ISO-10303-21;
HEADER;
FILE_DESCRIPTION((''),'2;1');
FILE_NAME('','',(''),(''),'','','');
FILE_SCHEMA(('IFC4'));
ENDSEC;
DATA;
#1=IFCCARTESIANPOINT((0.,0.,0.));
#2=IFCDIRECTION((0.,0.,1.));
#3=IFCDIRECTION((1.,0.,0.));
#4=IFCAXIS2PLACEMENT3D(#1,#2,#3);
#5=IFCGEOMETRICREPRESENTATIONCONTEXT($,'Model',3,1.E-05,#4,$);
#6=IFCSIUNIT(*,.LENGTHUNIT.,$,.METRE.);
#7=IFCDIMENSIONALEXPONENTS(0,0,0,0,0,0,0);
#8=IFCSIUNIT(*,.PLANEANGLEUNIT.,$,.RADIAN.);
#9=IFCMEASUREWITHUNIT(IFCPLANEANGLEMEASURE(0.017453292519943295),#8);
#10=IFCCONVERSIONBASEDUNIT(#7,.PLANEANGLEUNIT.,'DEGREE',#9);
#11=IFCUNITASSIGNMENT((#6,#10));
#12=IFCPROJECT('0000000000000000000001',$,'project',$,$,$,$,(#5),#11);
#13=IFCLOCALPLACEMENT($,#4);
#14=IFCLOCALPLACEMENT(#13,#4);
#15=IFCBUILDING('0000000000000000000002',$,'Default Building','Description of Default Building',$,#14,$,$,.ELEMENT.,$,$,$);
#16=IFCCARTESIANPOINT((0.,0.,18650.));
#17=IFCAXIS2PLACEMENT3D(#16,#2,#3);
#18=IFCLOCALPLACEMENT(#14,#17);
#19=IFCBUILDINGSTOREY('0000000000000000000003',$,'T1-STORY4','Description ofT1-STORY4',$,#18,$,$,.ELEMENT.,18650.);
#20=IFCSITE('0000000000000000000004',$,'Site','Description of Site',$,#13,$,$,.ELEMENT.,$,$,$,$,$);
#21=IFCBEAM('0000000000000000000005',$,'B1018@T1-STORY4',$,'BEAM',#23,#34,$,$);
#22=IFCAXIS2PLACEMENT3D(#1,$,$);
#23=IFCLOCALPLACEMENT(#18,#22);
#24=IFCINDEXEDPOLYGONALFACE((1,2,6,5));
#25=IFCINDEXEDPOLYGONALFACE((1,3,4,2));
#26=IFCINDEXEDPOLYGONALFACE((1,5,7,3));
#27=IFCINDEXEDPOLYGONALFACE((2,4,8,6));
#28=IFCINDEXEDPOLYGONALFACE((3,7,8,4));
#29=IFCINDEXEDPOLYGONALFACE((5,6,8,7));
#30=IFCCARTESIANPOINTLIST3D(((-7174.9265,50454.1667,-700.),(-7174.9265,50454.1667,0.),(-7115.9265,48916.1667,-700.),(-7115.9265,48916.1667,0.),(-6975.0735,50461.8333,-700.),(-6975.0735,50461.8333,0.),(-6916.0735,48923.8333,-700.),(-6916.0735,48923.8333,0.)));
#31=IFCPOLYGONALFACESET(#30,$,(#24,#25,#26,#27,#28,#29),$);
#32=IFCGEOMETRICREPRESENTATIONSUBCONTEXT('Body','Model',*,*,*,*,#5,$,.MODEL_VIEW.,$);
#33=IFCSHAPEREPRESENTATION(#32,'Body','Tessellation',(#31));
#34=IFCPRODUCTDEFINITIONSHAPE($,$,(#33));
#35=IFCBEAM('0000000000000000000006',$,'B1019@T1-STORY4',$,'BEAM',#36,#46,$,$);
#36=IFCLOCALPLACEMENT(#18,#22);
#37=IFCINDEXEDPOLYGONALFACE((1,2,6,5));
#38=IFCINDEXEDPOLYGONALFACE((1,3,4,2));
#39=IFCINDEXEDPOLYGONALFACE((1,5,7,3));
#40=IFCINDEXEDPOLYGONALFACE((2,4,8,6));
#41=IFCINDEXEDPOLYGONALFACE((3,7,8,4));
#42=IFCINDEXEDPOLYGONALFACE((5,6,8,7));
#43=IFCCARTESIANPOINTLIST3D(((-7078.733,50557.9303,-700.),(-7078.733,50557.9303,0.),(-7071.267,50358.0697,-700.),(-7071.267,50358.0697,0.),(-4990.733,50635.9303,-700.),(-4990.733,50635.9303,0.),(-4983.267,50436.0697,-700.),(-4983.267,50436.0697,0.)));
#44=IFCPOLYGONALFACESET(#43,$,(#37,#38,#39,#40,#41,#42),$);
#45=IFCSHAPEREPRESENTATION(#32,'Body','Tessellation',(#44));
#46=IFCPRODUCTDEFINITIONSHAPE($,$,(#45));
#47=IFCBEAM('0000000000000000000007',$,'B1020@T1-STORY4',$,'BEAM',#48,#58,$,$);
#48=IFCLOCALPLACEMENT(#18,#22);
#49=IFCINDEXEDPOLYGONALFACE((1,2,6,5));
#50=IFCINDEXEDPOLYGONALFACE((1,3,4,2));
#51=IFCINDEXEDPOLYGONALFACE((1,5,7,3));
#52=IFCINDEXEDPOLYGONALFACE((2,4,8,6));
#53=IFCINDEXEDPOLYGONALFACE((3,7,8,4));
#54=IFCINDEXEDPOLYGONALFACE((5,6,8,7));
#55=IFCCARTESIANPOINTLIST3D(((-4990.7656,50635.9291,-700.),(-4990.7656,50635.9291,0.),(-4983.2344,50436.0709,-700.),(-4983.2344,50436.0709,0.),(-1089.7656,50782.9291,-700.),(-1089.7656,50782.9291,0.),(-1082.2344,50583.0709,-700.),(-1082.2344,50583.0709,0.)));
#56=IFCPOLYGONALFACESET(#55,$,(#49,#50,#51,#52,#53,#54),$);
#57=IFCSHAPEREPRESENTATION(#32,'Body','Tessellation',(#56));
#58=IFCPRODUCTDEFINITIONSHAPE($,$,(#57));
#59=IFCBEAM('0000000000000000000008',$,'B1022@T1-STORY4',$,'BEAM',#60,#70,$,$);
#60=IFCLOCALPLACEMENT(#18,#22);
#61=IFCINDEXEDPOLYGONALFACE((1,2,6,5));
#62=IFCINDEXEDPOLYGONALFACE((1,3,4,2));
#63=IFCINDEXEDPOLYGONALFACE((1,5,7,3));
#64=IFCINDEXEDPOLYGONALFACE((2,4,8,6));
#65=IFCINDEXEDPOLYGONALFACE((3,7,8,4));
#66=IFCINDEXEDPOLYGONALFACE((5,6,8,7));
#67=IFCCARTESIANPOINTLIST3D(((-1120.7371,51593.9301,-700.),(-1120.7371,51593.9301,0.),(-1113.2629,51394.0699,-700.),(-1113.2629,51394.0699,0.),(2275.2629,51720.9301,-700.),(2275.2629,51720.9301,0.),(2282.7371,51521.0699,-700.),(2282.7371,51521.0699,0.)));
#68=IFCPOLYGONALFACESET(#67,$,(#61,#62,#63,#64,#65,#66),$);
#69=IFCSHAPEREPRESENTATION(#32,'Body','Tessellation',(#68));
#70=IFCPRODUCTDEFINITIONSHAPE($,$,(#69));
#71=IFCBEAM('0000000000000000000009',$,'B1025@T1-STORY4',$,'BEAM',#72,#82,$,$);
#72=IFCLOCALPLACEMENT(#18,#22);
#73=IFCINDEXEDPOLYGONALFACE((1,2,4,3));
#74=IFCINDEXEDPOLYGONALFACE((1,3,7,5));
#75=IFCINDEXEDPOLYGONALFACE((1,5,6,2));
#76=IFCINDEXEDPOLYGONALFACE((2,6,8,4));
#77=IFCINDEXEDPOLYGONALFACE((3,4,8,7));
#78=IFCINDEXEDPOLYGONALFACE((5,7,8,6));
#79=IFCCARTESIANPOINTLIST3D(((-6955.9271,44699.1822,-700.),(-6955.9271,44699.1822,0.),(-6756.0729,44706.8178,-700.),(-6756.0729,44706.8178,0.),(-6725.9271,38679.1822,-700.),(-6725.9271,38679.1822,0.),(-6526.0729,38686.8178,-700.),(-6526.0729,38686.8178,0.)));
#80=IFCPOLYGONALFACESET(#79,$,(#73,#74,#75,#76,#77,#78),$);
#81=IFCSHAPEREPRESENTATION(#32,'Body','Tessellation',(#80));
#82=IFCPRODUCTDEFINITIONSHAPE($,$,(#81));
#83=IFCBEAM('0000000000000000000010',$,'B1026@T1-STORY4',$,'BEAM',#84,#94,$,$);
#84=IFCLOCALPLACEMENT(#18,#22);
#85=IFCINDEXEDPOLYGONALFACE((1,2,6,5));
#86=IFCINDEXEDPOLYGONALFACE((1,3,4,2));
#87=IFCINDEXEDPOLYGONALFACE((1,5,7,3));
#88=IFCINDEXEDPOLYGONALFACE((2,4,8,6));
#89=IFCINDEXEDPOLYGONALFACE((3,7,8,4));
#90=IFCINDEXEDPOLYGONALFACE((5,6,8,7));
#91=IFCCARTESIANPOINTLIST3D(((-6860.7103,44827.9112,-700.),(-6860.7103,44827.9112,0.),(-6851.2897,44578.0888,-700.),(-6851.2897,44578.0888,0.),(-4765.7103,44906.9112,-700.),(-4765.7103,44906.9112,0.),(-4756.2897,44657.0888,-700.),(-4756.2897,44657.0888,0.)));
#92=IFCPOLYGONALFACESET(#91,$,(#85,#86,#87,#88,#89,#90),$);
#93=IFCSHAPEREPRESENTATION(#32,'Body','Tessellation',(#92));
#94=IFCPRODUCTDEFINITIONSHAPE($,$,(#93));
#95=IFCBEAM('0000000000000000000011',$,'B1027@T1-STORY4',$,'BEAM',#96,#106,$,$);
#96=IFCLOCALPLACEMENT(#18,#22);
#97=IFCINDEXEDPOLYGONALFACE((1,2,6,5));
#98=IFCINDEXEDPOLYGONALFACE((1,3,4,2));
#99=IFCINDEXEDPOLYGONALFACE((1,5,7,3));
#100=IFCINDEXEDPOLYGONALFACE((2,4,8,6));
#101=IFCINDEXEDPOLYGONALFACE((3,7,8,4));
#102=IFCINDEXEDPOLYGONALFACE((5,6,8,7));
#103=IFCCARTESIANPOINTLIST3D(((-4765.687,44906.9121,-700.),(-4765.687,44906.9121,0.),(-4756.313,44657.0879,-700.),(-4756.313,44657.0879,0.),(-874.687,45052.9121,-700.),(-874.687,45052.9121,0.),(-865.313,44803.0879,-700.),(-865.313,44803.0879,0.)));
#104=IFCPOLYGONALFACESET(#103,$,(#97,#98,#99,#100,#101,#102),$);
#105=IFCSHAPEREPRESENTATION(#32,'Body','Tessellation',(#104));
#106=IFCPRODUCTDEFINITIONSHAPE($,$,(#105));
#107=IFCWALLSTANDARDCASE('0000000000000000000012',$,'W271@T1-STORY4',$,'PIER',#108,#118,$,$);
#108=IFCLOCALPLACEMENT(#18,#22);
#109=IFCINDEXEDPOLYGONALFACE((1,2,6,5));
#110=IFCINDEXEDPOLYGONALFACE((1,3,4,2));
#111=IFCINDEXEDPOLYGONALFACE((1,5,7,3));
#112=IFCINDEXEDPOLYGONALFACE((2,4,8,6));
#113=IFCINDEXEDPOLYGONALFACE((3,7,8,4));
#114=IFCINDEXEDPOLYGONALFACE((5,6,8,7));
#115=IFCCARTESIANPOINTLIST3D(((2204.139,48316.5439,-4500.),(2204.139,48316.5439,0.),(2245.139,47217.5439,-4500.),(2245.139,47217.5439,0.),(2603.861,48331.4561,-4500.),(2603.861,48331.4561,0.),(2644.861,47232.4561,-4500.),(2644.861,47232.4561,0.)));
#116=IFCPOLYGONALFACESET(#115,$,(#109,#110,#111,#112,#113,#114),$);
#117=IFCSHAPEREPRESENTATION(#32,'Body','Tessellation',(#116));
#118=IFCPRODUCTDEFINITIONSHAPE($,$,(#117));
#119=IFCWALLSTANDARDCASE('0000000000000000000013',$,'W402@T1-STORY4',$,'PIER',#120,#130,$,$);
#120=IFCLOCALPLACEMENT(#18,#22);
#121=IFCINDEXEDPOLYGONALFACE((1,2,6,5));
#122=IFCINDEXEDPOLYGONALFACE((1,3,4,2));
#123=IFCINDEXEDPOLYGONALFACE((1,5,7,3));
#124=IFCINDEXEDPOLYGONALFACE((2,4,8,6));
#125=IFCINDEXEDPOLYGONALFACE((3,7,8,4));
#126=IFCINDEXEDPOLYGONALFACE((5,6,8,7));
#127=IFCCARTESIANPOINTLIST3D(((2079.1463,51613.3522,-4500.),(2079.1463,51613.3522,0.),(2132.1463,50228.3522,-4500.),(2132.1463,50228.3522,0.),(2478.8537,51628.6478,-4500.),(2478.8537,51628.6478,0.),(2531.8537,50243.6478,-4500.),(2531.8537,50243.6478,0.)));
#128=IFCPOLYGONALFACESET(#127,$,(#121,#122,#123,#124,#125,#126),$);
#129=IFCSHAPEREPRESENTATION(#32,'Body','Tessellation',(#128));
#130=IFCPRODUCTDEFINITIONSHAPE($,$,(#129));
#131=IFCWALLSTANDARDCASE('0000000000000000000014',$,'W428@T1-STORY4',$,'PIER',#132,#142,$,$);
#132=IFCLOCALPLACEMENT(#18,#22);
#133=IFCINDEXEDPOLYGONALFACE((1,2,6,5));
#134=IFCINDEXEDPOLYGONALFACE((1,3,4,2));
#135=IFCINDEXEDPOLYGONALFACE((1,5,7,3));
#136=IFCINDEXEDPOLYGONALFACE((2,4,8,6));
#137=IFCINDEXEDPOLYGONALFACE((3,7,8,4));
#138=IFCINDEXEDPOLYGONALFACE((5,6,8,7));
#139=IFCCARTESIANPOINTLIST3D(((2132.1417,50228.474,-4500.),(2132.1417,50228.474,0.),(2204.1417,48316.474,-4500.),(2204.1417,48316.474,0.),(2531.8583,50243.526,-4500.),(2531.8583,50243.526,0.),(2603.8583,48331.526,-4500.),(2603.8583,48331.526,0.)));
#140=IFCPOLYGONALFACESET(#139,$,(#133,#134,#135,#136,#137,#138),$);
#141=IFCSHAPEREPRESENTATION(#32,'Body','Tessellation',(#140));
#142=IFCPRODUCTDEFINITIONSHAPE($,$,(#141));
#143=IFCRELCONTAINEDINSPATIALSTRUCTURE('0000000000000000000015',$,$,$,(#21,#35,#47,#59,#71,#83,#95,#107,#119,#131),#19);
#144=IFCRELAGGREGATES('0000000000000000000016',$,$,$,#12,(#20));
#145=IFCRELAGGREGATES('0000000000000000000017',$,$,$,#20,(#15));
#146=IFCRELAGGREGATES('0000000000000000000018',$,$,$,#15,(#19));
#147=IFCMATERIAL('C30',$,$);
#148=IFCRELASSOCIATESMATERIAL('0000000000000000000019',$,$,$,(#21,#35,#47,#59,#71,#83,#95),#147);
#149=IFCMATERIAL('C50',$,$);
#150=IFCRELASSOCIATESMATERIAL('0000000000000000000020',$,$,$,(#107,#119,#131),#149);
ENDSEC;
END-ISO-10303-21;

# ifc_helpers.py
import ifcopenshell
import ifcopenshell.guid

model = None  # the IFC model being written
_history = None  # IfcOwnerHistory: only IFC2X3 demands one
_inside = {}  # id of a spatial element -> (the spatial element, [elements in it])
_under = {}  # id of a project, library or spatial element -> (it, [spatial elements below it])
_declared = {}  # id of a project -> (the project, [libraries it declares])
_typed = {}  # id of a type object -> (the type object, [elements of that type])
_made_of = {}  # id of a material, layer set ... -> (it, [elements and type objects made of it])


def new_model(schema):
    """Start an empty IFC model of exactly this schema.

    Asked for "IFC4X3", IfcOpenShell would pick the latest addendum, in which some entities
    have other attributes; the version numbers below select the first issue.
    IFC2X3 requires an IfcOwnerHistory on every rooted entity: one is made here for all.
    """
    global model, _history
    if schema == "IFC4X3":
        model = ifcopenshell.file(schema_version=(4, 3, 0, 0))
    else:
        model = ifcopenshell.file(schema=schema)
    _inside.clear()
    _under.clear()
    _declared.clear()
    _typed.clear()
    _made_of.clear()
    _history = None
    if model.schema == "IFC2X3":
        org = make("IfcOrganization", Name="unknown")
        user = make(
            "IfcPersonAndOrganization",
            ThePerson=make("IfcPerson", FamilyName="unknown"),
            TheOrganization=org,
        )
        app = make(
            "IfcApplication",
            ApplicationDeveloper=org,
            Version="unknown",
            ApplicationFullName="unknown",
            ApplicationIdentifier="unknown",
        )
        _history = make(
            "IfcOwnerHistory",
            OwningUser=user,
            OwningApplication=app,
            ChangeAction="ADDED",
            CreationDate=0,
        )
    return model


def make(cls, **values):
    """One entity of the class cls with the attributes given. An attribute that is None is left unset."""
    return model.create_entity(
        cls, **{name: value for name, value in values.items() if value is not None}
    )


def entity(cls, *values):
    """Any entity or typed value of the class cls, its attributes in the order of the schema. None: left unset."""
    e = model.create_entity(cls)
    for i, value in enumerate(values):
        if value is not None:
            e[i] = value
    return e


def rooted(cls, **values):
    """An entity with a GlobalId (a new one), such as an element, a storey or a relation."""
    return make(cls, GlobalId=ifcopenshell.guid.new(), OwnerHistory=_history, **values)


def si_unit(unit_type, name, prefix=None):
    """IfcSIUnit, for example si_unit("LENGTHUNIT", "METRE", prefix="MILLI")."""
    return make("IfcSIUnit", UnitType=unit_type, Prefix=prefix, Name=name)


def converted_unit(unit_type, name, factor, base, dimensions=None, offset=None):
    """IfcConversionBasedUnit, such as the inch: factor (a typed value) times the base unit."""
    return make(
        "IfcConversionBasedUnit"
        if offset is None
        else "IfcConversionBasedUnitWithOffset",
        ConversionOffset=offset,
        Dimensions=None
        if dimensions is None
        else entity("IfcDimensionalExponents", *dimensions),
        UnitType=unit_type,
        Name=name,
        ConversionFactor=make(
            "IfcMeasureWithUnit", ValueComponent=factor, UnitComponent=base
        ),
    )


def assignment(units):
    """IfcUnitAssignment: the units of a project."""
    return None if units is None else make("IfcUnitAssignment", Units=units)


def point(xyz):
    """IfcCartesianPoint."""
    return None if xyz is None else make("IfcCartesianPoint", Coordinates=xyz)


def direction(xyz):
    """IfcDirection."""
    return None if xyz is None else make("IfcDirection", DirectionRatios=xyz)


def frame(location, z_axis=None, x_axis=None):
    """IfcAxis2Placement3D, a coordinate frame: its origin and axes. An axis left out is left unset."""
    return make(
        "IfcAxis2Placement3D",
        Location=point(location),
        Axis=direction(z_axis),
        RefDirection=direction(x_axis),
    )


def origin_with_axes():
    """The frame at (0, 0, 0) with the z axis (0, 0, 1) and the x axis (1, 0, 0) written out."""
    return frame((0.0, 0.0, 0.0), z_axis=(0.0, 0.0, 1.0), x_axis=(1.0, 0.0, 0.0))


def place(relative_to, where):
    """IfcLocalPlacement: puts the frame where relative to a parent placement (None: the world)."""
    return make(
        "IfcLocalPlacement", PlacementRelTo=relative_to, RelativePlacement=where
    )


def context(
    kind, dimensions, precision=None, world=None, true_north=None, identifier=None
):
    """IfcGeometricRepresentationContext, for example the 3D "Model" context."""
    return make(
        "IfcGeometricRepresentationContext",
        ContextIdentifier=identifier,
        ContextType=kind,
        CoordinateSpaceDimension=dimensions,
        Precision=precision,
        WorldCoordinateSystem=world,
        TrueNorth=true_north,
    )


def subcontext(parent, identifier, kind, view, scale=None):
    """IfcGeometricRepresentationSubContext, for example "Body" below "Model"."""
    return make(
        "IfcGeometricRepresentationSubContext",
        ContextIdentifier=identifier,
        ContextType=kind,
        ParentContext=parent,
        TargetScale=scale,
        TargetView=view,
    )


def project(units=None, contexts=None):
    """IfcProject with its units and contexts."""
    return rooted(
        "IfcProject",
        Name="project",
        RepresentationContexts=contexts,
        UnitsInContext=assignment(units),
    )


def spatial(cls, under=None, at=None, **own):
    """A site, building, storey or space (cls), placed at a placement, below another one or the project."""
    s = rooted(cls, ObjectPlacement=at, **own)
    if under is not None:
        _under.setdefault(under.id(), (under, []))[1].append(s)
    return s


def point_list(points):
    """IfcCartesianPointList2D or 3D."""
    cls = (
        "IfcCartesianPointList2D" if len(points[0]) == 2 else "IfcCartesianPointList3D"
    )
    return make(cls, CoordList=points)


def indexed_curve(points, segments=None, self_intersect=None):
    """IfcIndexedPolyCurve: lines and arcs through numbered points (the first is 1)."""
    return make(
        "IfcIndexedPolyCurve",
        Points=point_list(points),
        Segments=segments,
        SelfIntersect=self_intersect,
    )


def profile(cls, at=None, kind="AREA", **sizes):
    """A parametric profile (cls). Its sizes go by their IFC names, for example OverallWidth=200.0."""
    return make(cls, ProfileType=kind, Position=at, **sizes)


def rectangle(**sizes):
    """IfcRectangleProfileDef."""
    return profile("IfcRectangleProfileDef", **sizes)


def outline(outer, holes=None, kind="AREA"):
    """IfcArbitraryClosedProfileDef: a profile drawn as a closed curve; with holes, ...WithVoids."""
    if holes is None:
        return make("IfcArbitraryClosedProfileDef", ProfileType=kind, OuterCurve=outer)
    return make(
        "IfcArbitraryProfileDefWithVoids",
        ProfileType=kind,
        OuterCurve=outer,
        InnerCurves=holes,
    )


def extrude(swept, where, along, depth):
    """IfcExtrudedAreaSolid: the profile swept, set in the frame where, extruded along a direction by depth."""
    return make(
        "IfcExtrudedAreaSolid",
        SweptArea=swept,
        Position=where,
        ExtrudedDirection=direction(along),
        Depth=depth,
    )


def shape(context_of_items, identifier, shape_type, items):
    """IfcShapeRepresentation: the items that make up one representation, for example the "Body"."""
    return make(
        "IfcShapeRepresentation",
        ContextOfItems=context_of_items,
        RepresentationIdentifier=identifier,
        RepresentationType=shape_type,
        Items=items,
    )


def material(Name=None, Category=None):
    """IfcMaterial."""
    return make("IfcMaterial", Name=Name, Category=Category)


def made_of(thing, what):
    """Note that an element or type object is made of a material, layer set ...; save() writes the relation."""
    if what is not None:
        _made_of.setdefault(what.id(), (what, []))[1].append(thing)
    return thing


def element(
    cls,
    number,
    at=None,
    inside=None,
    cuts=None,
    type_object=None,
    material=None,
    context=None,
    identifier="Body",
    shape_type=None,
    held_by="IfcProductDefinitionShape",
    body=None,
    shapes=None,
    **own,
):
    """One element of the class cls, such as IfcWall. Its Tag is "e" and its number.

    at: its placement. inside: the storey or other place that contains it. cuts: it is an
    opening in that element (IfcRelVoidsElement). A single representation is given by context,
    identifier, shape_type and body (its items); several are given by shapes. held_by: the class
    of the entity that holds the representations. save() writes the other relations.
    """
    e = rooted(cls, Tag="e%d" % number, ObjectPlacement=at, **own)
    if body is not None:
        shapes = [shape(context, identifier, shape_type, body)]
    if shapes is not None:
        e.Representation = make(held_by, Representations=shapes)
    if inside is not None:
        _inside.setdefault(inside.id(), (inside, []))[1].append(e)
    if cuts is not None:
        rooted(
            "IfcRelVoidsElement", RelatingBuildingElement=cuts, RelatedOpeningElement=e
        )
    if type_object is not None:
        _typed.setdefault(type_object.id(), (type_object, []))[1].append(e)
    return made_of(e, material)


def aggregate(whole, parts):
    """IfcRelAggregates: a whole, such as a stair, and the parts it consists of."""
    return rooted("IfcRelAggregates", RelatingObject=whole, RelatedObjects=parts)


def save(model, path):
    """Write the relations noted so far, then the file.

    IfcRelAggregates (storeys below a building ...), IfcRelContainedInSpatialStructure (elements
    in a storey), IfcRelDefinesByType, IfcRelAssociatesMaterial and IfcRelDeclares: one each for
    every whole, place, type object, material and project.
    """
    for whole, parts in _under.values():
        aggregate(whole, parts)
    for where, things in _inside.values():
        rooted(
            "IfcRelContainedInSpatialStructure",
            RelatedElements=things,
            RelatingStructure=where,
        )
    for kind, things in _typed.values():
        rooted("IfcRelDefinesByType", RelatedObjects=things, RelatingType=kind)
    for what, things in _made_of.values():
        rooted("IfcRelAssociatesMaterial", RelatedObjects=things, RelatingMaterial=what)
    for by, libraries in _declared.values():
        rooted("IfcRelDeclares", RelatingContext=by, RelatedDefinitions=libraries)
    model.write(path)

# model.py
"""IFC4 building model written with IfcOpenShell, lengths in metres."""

from ifc_helpers import new_model, entity, si_unit, converted_unit, frame, origin_with_axes, place, context, subcontext, project, spatial, indexed_curve, rectangle, outline, extrude, material, element, save


model = new_model("IFC4")

# Units and contexts
model_context = context("Model", 3, precision=1e-05, world=origin_with_axes())
body_context = subcontext(model_context, "Body", "Model", "MODEL_VIEW")
ifc_project = project(units=[si_unit("LENGTHUNIT", "METRE"), converted_unit("PLANEANGLEUNIT", "DEGREE", entity("IfcPlaneAngleMeasure", 0.017453292519943295), si_unit("PLANEANGLEUNIT", "RADIAN"), dimensions=[0, 0, 0, 0, 0, 0, 0])], contexts=[model_context])

# Site, building, storey
site_placement = place(None, origin_with_axes())
site = spatial("IfcSite", under=ifc_project, at=site_placement, Name="Site", Description="Description of Site", CompositionType="ELEMENT")
building_placement = place(site_placement, origin_with_axes())
building = spatial("IfcBuilding", under=site, at=building_placement, Name="Default Building", Description="Description of Default Building", CompositionType="ELEMENT")
storey_placement = place(building_placement, frame((0.0, 0.0, 18650.0), z_axis=(0.0, 0.0, 1.0), x_axis=(1.0, 0.0, 0.0)))
storey = spatial("IfcBuildingStorey", under=building, at=storey_placement, Name="T1-STORY4", Description="Description ofT1-STORY4", CompositionType="ELEMENT", Elevation=18650.0)

# Beams
ifc_material_1 = material(Name="C30")
beam_1_placement = place(storey_placement, frame((-7075.0, 50458.0, -350.0), z_axis=(0.038333, -0.999265, 0.0), x_axis=(0.999265, 0.038333, 0.0)))
element("IfcBeam", 1, at=beam_1_placement, inside=storey, material=ifc_material_1, Name="B1018@T1-STORY4", ObjectType="BEAM", context=body_context, shape_type="SweptSolid", body=[
    extrude(rectangle(XDim=200.0, YDim=700.0), origin_with_axes(), (0.0, 0.0, 1.0), 1539.1312),
])
beam_2_placement = place(storey_placement, frame((-7075.0, 50458.0, -350.0), z_axis=(0.999303, 0.03733, 0.0), x_axis=(-0.03733, 0.999303, 0.0)))
element("IfcBeam", 2, at=beam_2_placement, inside=storey, material=ifc_material_1, Name="B1019@T1-STORY4", ObjectType="BEAM", context=body_context, shape_type="SweptSolid", body=[
    extrude(rectangle(XDim=200.0, YDim=700.0), origin_with_axes(), (0.0, 0.0, 1.0), 2089.4564),
])
beam_3_placement = place(storey_placement, frame((-4987.0, 50536.0, -350.0), z_axis=(0.999291, 0.037656, 0.0), x_axis=(-0.037656, 0.999291, 0.0)))
element("IfcBeam", 3, at=beam_3_placement, inside=storey, material=ifc_material_1, Name="B1020@T1-STORY4", ObjectType="BEAM", context=body_context, shape_type="SweptSolid", body=[
    extrude(rectangle(XDim=200.0, YDim=700.0), origin_with_axes(), (0.0, 0.0, 1.0), 3903.7687),
])
beam_4_placement = place(storey_placement, frame((-1117.0, 51494.0, -350.0), z_axis=(0.999301, 0.037371, 0.0), x_axis=(-0.037371, 0.999301, 0.0)))
element("IfcBeam", 4, at=beam_4_placement, inside=storey, material=ifc_material_1, Name="B1022@T1-STORY4", ObjectType="BEAM", context=body_context, shape_type="SweptSolid", body=[
    extrude(rectangle(XDim=200.0, YDim=700.0), origin_with_axes(), (0.0, 0.0, 1.0), 3398.3739),
])
beam_5_placement = place(storey_placement, frame((-6856.0, 44703.0, -350.0), z_axis=(0.038178, -0.999271, 0.0), x_axis=(0.999271, 0.038178, 0.0)))
element("IfcBeam", 5, at=beam_5_placement, inside=storey, material=ifc_material_1, Name="B1025@T1-STORY4", ObjectType="BEAM", context=body_context, shape_type="SweptSolid", body=[
    extrude(rectangle(XDim=200.0, YDim=700.0), origin_with_axes(), (0.0, 0.0, 1.0), 6024.3921),
])
beam_6_placement = place(storey_placement, frame((-6856.0, 44703.0, -350.0), z_axis=(0.99929, 0.037682, 0.0), x_axis=(-0.037682, 0.99929, 0.0)))
element("IfcBeam", 6, at=beam_6_placement, inside=storey, material=ifc_material_1, Name="B1026@T1-STORY4", ObjectType="BEAM", context=body_context, shape_type="SweptSolid", body=[
    extrude(rectangle(XDim=250.0, YDim=700.0), origin_with_axes(), (0.0, 0.0, 1.0), 2096.489),
])
beam_7_placement = place(storey_placement, frame((-4761.0, 44782.0, -350.0), z_axis=(0.999297, 0.037496, 0.0), x_axis=(-0.037496, 0.999297, 0.0)))
element("IfcBeam", 7, at=beam_7_placement, inside=storey, material=ifc_material_1, Name="B1027@T1-STORY4", ObjectType="BEAM", context=body_context, shape_type="SweptSolid", body=[
    extrude(rectangle(XDim=250.0, YDim=700.0), origin_with_axes(), (0.0, 0.0, 1.0), 3893.7382),
])
ifc_material_2 = material(Name="C50")

# Walls
wall_1_placement = place(storey_placement, frame((2404.0, 48324.0, -4500.0), z_axis=(0.0, 0.0, 1.0), x_axis=(0.037281, -0.999305, 0.0)))
element("IfcWallStandardCase", 8, at=wall_1_placement, inside=storey, material=ifc_material_2, Name="W271@T1-STORY4", ObjectType="PIER", context=body_context, shape_type="SweptSolid", body=[
    extrude(outline(indexed_curve([(0.0, -200.0), (0.0, 200.0), (1099.7645, 200.0), (1099.7645, -200.0), (0.0, -200.0)], self_intersect=False)), origin_with_axes(), (0.0, 0.0, 1.0), 4500.0),
])
wall_2_placement = place(storey_placement, frame((2279.0, 51621.0, -4500.0), z_axis=(0.0, 0.0, 1.0), x_axis=(0.038239, -0.999269, 0.0)))
element("IfcWallStandardCase", 9, at=wall_2_placement, inside=storey, material=ifc_material_2, Name="W402@T1-STORY4", ObjectType="PIER", context=body_context, shape_type="SweptSolid", body=[
    extrude(outline(indexed_curve([(0.0, -200.0), (0.0, 200.0), (1386.0137, 200.0), (1386.0137, -200.0), (0.0, -200.0)], self_intersect=False)), origin_with_axes(), (0.0, 0.0, 1.0), 4500.0),
])
wall_3_placement = place(storey_placement, frame((2332.0, 50236.0, -4500.0), z_axis=(0.0, 0.0, 1.0), x_axis=(0.03763, -0.999292, 0.0)))
element("IfcWallStandardCase", 10, at=wall_3_placement, inside=storey, material=ifc_material_2, Name="W428@T1-STORY4", ObjectType="PIER", context=body_context, shape_type="SweptSolid", body=[
    extrude(outline(indexed_curve([(0.0, -200.0), (0.0, 200.0), (1913.3552, 200.0), (1913.3552, -200.0), (0.0, -200.0)], self_intersect=False)), origin_with_axes(), (0.0, 0.0, 1.0), 4500.0),
])

save(model, "model.ifc")
